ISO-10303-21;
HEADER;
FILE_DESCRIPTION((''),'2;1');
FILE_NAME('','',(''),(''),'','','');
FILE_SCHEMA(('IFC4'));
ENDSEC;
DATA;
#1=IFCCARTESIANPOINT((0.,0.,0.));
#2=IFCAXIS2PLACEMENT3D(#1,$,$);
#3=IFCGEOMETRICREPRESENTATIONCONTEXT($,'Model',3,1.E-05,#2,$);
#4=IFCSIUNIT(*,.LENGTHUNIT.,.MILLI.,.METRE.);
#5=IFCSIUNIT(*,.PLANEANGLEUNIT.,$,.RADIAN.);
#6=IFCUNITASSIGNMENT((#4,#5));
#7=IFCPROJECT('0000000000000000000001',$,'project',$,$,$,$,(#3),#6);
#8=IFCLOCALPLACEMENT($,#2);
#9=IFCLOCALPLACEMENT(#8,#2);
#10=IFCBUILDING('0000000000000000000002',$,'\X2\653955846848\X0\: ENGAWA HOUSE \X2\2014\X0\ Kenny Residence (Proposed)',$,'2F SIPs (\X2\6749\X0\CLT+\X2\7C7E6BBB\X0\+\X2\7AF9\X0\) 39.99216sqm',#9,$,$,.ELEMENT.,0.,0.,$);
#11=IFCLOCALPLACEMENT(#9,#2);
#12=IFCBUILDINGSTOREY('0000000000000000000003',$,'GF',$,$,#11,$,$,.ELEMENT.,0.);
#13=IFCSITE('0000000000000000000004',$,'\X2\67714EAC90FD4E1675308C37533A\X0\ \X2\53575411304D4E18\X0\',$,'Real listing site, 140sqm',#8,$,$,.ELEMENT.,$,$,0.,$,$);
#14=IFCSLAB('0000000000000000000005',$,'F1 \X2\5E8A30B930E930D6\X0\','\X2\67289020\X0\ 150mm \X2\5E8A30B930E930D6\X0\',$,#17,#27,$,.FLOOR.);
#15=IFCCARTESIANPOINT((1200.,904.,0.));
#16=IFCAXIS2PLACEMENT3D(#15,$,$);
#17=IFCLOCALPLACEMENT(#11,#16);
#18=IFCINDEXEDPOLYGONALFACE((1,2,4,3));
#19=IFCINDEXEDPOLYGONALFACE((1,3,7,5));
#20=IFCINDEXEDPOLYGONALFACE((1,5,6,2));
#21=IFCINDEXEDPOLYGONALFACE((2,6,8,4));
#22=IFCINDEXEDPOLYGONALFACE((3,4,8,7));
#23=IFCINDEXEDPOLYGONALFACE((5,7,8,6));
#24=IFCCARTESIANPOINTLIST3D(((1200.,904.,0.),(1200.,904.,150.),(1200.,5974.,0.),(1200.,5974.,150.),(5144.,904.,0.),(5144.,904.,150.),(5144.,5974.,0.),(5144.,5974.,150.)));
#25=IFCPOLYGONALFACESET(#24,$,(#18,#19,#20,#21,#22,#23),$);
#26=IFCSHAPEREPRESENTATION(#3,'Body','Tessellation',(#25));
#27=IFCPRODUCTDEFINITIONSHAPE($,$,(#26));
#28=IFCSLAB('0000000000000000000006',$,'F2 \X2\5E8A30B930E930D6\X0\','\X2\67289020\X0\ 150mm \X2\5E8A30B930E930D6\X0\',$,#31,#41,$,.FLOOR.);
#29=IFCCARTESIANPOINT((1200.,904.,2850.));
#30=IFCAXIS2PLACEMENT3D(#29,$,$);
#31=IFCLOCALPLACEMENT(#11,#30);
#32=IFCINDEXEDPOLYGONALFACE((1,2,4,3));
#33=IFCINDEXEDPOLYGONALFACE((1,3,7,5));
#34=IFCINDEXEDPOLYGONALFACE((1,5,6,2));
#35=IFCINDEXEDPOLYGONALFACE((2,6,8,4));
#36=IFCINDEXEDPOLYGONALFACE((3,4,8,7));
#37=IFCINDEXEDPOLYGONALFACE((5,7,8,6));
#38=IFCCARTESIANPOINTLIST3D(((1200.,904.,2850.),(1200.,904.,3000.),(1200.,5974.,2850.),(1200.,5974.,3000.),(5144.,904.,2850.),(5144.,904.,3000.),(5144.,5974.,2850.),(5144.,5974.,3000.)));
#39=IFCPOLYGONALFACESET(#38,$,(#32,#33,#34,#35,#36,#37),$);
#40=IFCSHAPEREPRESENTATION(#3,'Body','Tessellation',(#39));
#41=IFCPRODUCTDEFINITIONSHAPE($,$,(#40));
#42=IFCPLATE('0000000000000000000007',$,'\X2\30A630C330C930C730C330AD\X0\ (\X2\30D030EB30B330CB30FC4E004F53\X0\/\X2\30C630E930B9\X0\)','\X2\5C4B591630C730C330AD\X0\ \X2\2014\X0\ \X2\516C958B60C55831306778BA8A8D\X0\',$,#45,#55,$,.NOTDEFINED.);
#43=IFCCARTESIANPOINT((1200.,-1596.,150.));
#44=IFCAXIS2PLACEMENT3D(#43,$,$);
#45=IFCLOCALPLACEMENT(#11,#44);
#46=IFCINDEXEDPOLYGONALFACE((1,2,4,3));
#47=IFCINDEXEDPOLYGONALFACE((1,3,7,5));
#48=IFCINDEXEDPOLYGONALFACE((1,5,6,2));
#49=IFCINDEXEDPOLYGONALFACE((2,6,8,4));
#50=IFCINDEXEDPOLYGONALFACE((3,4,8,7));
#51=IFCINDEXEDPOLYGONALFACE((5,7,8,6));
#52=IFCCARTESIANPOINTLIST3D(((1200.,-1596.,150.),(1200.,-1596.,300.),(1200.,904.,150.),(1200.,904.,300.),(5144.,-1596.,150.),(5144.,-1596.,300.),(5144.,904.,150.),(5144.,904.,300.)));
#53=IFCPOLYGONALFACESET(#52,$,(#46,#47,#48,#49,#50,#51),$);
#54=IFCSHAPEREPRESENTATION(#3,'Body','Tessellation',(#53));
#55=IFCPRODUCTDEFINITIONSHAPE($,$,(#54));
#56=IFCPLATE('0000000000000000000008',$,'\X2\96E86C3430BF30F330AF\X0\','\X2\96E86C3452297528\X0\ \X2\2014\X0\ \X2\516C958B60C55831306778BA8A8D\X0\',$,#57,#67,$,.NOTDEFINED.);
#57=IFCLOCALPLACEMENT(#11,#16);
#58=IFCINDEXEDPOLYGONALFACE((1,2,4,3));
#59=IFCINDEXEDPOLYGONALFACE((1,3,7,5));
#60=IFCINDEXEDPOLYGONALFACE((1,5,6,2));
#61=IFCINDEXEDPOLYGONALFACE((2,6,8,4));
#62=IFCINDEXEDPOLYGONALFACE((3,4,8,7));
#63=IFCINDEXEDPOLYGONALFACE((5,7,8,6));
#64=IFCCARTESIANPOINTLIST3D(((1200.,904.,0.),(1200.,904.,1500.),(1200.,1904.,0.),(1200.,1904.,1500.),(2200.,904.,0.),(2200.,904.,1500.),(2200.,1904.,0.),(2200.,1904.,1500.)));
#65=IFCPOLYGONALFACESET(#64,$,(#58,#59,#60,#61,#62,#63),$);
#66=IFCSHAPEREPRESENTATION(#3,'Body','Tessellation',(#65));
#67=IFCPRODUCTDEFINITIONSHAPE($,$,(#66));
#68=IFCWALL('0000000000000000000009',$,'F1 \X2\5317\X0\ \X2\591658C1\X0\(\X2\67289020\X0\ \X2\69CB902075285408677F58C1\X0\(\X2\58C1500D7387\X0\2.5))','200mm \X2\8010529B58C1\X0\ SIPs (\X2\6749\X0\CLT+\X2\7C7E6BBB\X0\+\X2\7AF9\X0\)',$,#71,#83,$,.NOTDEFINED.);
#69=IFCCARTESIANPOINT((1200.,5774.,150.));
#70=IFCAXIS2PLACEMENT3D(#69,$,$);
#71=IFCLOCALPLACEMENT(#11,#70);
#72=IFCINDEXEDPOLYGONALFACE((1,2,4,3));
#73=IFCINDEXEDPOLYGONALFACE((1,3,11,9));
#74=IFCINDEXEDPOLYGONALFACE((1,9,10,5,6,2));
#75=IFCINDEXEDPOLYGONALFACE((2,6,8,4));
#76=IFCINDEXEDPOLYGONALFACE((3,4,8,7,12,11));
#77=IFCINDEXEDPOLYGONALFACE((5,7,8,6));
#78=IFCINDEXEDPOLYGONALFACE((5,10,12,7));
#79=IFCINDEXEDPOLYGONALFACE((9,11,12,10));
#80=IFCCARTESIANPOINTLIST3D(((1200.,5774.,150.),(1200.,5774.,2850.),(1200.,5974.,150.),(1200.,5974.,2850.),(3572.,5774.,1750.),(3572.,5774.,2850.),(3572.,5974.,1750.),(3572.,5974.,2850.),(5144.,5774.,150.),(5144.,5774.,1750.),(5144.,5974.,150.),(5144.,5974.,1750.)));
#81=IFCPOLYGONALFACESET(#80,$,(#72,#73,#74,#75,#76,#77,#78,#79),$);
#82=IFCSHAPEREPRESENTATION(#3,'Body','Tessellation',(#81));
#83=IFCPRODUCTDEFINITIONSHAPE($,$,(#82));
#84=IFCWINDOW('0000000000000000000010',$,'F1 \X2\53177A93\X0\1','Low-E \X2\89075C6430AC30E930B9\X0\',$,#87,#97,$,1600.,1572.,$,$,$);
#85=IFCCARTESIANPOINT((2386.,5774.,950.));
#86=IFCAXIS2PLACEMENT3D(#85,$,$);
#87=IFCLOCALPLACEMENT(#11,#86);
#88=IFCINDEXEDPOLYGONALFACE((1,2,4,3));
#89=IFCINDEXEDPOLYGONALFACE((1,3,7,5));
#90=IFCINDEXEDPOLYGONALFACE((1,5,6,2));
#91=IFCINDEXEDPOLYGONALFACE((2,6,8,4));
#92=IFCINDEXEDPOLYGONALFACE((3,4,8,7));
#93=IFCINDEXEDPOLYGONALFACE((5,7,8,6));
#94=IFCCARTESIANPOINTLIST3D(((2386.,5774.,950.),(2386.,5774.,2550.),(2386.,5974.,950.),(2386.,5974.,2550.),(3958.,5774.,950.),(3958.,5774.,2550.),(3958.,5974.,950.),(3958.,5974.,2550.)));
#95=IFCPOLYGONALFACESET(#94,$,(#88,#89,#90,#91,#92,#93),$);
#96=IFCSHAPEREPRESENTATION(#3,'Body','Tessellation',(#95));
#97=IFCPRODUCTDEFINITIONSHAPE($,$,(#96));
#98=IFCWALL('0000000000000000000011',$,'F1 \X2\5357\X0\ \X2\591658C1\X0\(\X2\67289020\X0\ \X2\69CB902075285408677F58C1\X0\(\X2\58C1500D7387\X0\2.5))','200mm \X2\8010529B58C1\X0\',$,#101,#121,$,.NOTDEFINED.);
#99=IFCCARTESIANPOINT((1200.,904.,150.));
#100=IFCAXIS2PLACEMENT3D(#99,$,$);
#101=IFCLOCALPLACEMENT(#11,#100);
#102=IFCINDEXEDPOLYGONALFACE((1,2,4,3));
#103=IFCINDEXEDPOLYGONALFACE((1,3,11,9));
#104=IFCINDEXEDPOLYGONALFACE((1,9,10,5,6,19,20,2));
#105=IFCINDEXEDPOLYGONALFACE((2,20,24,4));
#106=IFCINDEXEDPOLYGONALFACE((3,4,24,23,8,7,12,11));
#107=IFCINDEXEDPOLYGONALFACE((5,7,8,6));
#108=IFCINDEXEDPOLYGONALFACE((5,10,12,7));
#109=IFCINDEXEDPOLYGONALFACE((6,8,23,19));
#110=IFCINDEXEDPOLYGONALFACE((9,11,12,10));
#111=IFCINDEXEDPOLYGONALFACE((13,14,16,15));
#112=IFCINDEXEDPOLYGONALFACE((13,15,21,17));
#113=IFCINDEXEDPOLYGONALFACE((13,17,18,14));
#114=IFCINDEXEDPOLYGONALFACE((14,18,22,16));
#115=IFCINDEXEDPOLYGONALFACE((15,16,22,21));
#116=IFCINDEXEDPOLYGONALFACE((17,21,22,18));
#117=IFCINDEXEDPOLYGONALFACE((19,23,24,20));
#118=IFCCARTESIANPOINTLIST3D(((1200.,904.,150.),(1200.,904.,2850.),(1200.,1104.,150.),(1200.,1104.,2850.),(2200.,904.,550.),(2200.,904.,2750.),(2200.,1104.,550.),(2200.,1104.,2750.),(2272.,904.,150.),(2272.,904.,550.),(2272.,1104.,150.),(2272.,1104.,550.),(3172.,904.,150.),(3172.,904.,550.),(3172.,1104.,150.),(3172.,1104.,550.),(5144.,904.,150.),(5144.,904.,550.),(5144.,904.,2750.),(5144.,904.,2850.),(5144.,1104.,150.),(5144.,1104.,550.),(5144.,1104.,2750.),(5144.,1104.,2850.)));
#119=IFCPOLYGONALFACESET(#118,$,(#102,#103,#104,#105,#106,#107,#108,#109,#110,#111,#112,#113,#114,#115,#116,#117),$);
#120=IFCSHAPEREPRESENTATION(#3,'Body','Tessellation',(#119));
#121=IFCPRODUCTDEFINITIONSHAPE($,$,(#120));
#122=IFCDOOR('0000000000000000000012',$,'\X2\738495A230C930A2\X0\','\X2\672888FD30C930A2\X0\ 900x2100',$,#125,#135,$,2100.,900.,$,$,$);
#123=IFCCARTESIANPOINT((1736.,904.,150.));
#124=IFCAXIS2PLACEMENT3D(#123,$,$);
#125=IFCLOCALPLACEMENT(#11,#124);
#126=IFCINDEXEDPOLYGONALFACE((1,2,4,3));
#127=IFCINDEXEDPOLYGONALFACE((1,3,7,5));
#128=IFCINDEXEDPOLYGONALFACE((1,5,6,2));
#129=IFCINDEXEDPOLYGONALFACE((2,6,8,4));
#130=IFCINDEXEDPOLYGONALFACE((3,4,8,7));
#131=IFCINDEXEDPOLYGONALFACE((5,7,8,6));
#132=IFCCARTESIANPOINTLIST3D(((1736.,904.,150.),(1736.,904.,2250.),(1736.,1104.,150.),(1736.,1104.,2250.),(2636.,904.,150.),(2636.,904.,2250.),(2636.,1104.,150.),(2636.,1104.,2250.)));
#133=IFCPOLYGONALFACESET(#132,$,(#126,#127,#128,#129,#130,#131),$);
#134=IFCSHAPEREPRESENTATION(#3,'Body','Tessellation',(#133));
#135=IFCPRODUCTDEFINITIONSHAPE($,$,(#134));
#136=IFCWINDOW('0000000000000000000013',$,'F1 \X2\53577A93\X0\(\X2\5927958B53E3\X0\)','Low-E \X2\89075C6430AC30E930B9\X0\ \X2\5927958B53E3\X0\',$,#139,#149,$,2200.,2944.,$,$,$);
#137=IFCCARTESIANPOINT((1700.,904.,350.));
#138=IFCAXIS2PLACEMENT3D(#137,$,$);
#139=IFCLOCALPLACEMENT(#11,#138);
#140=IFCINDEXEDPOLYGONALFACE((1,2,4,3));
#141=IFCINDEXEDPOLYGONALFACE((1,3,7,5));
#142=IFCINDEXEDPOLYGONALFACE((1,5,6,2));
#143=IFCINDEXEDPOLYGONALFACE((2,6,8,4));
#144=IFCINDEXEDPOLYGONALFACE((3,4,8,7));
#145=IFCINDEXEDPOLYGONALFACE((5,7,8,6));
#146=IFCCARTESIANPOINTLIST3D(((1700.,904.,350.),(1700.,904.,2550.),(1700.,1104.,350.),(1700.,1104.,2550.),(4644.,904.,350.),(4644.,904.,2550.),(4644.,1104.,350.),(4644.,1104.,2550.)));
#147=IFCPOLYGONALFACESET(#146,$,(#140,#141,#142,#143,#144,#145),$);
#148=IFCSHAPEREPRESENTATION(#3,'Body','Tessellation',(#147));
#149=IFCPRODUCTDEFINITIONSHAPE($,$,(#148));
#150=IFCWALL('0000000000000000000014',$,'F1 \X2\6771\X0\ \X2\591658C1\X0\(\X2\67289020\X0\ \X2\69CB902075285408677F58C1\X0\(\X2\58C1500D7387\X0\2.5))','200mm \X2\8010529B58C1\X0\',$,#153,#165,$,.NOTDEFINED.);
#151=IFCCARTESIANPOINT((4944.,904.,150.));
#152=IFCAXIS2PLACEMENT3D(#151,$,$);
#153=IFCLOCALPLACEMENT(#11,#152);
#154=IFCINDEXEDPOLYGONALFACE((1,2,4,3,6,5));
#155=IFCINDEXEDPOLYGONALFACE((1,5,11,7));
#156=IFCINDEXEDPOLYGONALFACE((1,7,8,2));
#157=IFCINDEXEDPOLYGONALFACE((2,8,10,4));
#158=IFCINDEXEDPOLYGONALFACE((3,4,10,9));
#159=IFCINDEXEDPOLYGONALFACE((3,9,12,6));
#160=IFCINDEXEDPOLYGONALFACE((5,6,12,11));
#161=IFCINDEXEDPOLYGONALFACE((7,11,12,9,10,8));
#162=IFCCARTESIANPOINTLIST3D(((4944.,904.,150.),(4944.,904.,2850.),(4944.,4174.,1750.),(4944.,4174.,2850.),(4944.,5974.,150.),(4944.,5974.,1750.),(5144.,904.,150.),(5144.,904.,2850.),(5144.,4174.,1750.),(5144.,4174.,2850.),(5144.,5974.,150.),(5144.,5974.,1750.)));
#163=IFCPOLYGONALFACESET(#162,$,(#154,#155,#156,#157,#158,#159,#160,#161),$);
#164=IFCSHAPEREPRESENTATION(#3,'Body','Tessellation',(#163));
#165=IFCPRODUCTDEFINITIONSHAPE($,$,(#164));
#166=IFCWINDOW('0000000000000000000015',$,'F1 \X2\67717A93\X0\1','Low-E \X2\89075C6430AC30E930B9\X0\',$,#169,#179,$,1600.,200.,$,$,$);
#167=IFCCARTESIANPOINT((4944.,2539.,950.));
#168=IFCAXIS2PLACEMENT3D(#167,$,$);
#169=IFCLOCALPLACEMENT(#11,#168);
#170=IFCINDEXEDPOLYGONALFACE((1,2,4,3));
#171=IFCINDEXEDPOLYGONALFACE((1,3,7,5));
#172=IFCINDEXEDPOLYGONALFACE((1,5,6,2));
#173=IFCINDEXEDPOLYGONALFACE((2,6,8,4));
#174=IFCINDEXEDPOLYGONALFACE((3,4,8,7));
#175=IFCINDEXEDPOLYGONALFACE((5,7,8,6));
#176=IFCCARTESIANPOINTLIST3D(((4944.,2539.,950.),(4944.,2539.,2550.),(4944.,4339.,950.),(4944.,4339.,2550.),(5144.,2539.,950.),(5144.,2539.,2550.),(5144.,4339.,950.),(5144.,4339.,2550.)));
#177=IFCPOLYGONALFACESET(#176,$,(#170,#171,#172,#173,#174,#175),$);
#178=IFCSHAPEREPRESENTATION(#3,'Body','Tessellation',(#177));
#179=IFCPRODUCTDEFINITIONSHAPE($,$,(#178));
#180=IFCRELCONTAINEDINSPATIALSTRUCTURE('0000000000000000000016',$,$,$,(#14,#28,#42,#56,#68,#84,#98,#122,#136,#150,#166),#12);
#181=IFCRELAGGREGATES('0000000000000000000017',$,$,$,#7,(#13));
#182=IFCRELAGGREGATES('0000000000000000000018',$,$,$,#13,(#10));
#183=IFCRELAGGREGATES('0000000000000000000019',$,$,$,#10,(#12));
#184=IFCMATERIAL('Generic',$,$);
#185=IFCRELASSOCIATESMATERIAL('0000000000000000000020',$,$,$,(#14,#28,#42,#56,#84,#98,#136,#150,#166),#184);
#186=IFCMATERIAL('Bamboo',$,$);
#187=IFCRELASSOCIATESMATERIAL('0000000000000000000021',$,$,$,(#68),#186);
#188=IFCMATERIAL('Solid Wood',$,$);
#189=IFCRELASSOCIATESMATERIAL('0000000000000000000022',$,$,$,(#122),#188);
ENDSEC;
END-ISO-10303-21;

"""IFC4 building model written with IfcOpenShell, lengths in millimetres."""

from ifc_helpers import new_model, si_unit, frame, frame_2d, origin, place, context, project, spatial, rectangle, extrude, material, element, fill, save


model = new_model("IFC4")

# Units and contexts
model_context = context("Model", 3, precision=1e-05, world=origin())
ifc_project = project(units=[si_unit("LENGTHUNIT", "METRE", prefix="MILLI"), si_unit("PLANEANGLEUNIT", "RADIAN")], contexts=[model_context])

# Site, building, storey
site_placement = place(None, origin())
site = spatial("IfcSite", under=ifc_project, at=site_placement, Name="東京都世田谷区 南向き丘", ObjectType="Real listing site, 140sqm", CompositionType="ELEMENT", RefElevation=0.0)
building_placement = place(site_placement, origin())
building = spatial("IfcBuilding", under=site, at=building_placement, Name="改善案: ENGAWA HOUSE — Kenny Residence (Proposed)", ObjectType="2F SIPs (杉CLT+籾殻+竹) 39.99216sqm", CompositionType="ELEMENT", ElevationOfRefHeight=0.0, ElevationOfTerrain=0.0)
storey_placement = place(building_placement, origin())
storey = spatial("IfcBuildingStorey", under=building, at=storey_placement, Name="GF", CompositionType="ELEMENT", Elevation=0.0)

# Slabs
ifc_material_1 = material(Name="Generic")
slab_1_placement = place(storey_placement, frame((1200.0, 904.0, 0.0)))
element("IfcSlab", 1, at=slab_1_placement, inside=storey, material=ifc_material_1, Name="F1 床スラブ", Description="木造 150mm 床スラブ", PredefinedType="FLOOR", context=model_context, shape_type="SweptSolid", body=[
    extrude(rectangle(XDim=3944.0, YDim=5070.0, at=frame_2d((1972.0, 2535.0))), frame((1200.0, 904.0, 0.0)), (0.0, 0.0, 1.0), 150.0),
])
slab_2_placement = place(storey_placement, frame((1200.0, 904.0, 2850.0)))
element("IfcSlab", 2, at=slab_2_placement, inside=storey, material=ifc_material_1, Name="F2 床スラブ", Description="木造 150mm 床スラブ", PredefinedType="FLOOR", context=model_context, shape_type="SweptSolid", body=[
    extrude(rectangle(XDim=3944.0, YDim=5070.0, at=frame_2d((1972.0, 2535.0))), frame((1200.0, 904.0, 2850.0)), (0.0, 0.0, 1.0), 150.0),
])

# Plates
plate_1_placement = place(storey_placement, frame((1200.0, -1596.0, 150.0)))
element("IfcPlate", 3, at=plate_1_placement, inside=storey, material=ifc_material_1, Name="ウッドデッキ (バルコニー一体/テラス)", Description="屋外デッキ — 公開情報で確認", PredefinedType="NOTDEFINED", context=model_context, shape_type="SweptSolid", body=[
    extrude(rectangle(XDim=3944.0, YDim=2500.0, at=frame_2d((1972.0, 1250.0))), frame((1200.0, -1596.0, 150.0)), (0.0, 0.0, 1.0), 150.0),
])
plate_2_placement = place(storey_placement, frame((1200.0, 904.0, 0.0)))
element("IfcPlate", 4, at=plate_2_placement, inside=storey, material=ifc_material_1, Name="雨水タンク", Description="雨水利用 — 公開情報で確認", PredefinedType="NOTDEFINED", context=model_context, shape_type="SweptSolid", body=[
    extrude(rectangle(XDim=1000.0, YDim=1000.0, at=frame_2d((500.0, 500.0))), frame((1200.0, 904.0, 0.0)), (0.0, 0.0, 1.0), 1500.0),
])

# Wall, opening, window
ifc_material_2 = material(Name="Bamboo")
wall_1_placement = place(storey_placement, frame((1200.0, 5774.0, 150.0)))
wall_1 = element("IfcWall", 5, at=wall_1_placement, inside=storey, material=ifc_material_2, Name="F1 北 外壁(木造 構造用合板壁(壁倍率2.5))", Description="200mm 耐力壁 SIPs (杉CLT+籾殻+竹)", PredefinedType="NOTDEFINED", context=model_context, shape_type="SweptSolid", body=[
    extrude(rectangle(XDim=3944.0, YDim=200.0, at=frame_2d((1972.0, 100.0))), frame((1200.0, 5774.0, 150.0)), (0.0, 0.0, 1.0), 2700.0),
])
opening_1_placement = place(storey_placement, frame((2386.0, 5774.0, 950.0)))
opening_1 = element("IfcOpeningElement", 6, at=opening_1_placement, cuts=wall_1, PredefinedType="NOTDEFINED", context=model_context, shape_type="SweptSolid", body=[
    extrude(rectangle(XDim=1572.0, YDim=200.0, at=frame_2d((786.0, 100.0))), frame((2386.0, 5774.0, 950.0)), (0.0, 0.0, 1.0), 1600.0),
])
window_1_placement = place(storey_placement, frame((2386.0, 5774.0, 950.0)))
window_1 = element("IfcWindow", 7, at=window_1_placement, inside=storey, material=ifc_material_1, Name="F1 北窓1", Description="Low-E 複層ガラス", OverallHeight=1600.0, OverallWidth=1572.0, context=model_context, shape_type="SweptSolid", body=[
    extrude(rectangle(XDim=1572.0, YDim=200.0, at=frame_2d((786.0, 100.0))), frame((2386.0, 5774.0, 950.0)), (0.0, 0.0, 1.0), 1600.0),
])
fill(opening_1, window_1)

# Wall, openings, door, window
wall_2_placement = place(storey_placement, frame((1200.0, 904.0, 150.0)))
wall_2 = element("IfcWall", 8, at=wall_2_placement, inside=storey, material=ifc_material_1, Name="F1 南 外壁(木造 構造用合板壁(壁倍率2.5))", Description="200mm 耐力壁", PredefinedType="NOTDEFINED", context=model_context, shape_type="SweptSolid", body=[
    extrude(rectangle(XDim=3944.0, YDim=200.0, at=frame_2d((1972.0, 100.0))), frame((1200.0, 904.0, 150.0)), (0.0, 0.0, 1.0), 2700.0),
])
opening_2_placement = place(storey_placement, frame((1736.0, 904.0, 150.0)))
opening_2 = element("IfcOpeningElement", 9, at=opening_2_placement, cuts=wall_2, PredefinedType="NOTDEFINED", context=model_context, shape_type="SweptSolid", body=[
    extrude(rectangle(XDim=900.0, YDim=200.0, at=frame_2d((450.0, 100.0))), frame((1736.0, 904.0, 150.0)), (0.0, 0.0, 1.0), 2100.0),
])
opening_3_placement = place(storey_placement, frame((1700.0, 904.0, 350.0)))
opening_3 = element("IfcOpeningElement", 10, at=opening_3_placement, cuts=wall_2, PredefinedType="NOTDEFINED", context=model_context, shape_type="SweptSolid", body=[
    extrude(rectangle(XDim=2944.0, YDim=200.0, at=frame_2d((1472.0, 100.0))), frame((1700.0, 904.0, 350.0)), (0.0, 0.0, 1.0), 2200.0),
])
ifc_material_3 = material(Name="Solid Wood")
door_placement = place(storey_placement, frame((1736.0, 904.0, 150.0)))
door = element("IfcDoor", 11, at=door_placement, inside=storey, material=ifc_material_3, Name="玄関ドア", Description="木製ドア 900x2100", OverallHeight=2100.0, OverallWidth=900.0, context=model_context, shape_type="SweptSolid", body=[
    extrude(rectangle(XDim=900.0, YDim=200.0, at=frame_2d((450.0, 100.0))), frame((1736.0, 904.0, 150.0)), (0.0, 0.0, 1.0), 2100.0),
])
fill(opening_2, door)
window_2_placement = place(storey_placement, frame((1700.0, 904.0, 350.0)))
window_2 = element("IfcWindow", 12, at=window_2_placement, inside=storey, material=ifc_material_1, Name="F1 南窓(大開口)", Description="Low-E 複層ガラス 大開口", OverallHeight=2200.0, OverallWidth=2944.0, context=model_context, shape_type="SweptSolid", body=[
    extrude(rectangle(XDim=2944.0, YDim=200.0, at=frame_2d((1472.0, 100.0))), frame((1700.0, 904.0, 350.0)), (0.0, 0.0, 1.0), 2200.0),
])
fill(opening_3, window_2)

# Wall, opening, window
wall_3_placement = place(storey_placement, frame((4944.0, 904.0, 150.0)))
wall_3 = element("IfcWall", 13, at=wall_3_placement, inside=storey, material=ifc_material_1, Name="F1 東 外壁(木造 構造用合板壁(壁倍率2.5))", Description="200mm 耐力壁", PredefinedType="NOTDEFINED", context=model_context, shape_type="SweptSolid", body=[
    extrude(rectangle(XDim=200.0, YDim=5070.0, at=frame_2d((100.0, 2535.0))), frame((4944.0, 904.0, 150.0)), (0.0, 0.0, 1.0), 2700.0),
])
opening_4_placement = place(storey_placement, frame((4944.0, 2539.0, 950.0)))
opening_4 = element("IfcOpeningElement", 14, at=opening_4_placement, cuts=wall_3, PredefinedType="NOTDEFINED", context=model_context, shape_type="SweptSolid", body=[
    extrude(rectangle(XDim=200.0, YDim=1800.0, at=frame_2d((100.0, 900.0))), frame((4944.0, 2539.0, 950.0)), (0.0, 0.0, 1.0), 1600.0),
])
window_3_placement = place(storey_placement, frame((4944.0, 2539.0, 950.0)))
window_3 = element("IfcWindow", 15, at=window_3_placement, inside=storey, material=ifc_material_1, Name="F1 東窓1", Description="Low-E 複層ガラス", OverallHeight=1600.0, OverallWidth=200.0, context=model_context, shape_type="SweptSolid", body=[
    extrude(rectangle(XDim=200.0, YDim=1800.0, at=frame_2d((100.0, 900.0))), frame((4944.0, 2539.0, 950.0)), (0.0, 0.0, 1.0), 1600.0),
])
fill(opening_4, window_3)

save(model, "model.ifc")
